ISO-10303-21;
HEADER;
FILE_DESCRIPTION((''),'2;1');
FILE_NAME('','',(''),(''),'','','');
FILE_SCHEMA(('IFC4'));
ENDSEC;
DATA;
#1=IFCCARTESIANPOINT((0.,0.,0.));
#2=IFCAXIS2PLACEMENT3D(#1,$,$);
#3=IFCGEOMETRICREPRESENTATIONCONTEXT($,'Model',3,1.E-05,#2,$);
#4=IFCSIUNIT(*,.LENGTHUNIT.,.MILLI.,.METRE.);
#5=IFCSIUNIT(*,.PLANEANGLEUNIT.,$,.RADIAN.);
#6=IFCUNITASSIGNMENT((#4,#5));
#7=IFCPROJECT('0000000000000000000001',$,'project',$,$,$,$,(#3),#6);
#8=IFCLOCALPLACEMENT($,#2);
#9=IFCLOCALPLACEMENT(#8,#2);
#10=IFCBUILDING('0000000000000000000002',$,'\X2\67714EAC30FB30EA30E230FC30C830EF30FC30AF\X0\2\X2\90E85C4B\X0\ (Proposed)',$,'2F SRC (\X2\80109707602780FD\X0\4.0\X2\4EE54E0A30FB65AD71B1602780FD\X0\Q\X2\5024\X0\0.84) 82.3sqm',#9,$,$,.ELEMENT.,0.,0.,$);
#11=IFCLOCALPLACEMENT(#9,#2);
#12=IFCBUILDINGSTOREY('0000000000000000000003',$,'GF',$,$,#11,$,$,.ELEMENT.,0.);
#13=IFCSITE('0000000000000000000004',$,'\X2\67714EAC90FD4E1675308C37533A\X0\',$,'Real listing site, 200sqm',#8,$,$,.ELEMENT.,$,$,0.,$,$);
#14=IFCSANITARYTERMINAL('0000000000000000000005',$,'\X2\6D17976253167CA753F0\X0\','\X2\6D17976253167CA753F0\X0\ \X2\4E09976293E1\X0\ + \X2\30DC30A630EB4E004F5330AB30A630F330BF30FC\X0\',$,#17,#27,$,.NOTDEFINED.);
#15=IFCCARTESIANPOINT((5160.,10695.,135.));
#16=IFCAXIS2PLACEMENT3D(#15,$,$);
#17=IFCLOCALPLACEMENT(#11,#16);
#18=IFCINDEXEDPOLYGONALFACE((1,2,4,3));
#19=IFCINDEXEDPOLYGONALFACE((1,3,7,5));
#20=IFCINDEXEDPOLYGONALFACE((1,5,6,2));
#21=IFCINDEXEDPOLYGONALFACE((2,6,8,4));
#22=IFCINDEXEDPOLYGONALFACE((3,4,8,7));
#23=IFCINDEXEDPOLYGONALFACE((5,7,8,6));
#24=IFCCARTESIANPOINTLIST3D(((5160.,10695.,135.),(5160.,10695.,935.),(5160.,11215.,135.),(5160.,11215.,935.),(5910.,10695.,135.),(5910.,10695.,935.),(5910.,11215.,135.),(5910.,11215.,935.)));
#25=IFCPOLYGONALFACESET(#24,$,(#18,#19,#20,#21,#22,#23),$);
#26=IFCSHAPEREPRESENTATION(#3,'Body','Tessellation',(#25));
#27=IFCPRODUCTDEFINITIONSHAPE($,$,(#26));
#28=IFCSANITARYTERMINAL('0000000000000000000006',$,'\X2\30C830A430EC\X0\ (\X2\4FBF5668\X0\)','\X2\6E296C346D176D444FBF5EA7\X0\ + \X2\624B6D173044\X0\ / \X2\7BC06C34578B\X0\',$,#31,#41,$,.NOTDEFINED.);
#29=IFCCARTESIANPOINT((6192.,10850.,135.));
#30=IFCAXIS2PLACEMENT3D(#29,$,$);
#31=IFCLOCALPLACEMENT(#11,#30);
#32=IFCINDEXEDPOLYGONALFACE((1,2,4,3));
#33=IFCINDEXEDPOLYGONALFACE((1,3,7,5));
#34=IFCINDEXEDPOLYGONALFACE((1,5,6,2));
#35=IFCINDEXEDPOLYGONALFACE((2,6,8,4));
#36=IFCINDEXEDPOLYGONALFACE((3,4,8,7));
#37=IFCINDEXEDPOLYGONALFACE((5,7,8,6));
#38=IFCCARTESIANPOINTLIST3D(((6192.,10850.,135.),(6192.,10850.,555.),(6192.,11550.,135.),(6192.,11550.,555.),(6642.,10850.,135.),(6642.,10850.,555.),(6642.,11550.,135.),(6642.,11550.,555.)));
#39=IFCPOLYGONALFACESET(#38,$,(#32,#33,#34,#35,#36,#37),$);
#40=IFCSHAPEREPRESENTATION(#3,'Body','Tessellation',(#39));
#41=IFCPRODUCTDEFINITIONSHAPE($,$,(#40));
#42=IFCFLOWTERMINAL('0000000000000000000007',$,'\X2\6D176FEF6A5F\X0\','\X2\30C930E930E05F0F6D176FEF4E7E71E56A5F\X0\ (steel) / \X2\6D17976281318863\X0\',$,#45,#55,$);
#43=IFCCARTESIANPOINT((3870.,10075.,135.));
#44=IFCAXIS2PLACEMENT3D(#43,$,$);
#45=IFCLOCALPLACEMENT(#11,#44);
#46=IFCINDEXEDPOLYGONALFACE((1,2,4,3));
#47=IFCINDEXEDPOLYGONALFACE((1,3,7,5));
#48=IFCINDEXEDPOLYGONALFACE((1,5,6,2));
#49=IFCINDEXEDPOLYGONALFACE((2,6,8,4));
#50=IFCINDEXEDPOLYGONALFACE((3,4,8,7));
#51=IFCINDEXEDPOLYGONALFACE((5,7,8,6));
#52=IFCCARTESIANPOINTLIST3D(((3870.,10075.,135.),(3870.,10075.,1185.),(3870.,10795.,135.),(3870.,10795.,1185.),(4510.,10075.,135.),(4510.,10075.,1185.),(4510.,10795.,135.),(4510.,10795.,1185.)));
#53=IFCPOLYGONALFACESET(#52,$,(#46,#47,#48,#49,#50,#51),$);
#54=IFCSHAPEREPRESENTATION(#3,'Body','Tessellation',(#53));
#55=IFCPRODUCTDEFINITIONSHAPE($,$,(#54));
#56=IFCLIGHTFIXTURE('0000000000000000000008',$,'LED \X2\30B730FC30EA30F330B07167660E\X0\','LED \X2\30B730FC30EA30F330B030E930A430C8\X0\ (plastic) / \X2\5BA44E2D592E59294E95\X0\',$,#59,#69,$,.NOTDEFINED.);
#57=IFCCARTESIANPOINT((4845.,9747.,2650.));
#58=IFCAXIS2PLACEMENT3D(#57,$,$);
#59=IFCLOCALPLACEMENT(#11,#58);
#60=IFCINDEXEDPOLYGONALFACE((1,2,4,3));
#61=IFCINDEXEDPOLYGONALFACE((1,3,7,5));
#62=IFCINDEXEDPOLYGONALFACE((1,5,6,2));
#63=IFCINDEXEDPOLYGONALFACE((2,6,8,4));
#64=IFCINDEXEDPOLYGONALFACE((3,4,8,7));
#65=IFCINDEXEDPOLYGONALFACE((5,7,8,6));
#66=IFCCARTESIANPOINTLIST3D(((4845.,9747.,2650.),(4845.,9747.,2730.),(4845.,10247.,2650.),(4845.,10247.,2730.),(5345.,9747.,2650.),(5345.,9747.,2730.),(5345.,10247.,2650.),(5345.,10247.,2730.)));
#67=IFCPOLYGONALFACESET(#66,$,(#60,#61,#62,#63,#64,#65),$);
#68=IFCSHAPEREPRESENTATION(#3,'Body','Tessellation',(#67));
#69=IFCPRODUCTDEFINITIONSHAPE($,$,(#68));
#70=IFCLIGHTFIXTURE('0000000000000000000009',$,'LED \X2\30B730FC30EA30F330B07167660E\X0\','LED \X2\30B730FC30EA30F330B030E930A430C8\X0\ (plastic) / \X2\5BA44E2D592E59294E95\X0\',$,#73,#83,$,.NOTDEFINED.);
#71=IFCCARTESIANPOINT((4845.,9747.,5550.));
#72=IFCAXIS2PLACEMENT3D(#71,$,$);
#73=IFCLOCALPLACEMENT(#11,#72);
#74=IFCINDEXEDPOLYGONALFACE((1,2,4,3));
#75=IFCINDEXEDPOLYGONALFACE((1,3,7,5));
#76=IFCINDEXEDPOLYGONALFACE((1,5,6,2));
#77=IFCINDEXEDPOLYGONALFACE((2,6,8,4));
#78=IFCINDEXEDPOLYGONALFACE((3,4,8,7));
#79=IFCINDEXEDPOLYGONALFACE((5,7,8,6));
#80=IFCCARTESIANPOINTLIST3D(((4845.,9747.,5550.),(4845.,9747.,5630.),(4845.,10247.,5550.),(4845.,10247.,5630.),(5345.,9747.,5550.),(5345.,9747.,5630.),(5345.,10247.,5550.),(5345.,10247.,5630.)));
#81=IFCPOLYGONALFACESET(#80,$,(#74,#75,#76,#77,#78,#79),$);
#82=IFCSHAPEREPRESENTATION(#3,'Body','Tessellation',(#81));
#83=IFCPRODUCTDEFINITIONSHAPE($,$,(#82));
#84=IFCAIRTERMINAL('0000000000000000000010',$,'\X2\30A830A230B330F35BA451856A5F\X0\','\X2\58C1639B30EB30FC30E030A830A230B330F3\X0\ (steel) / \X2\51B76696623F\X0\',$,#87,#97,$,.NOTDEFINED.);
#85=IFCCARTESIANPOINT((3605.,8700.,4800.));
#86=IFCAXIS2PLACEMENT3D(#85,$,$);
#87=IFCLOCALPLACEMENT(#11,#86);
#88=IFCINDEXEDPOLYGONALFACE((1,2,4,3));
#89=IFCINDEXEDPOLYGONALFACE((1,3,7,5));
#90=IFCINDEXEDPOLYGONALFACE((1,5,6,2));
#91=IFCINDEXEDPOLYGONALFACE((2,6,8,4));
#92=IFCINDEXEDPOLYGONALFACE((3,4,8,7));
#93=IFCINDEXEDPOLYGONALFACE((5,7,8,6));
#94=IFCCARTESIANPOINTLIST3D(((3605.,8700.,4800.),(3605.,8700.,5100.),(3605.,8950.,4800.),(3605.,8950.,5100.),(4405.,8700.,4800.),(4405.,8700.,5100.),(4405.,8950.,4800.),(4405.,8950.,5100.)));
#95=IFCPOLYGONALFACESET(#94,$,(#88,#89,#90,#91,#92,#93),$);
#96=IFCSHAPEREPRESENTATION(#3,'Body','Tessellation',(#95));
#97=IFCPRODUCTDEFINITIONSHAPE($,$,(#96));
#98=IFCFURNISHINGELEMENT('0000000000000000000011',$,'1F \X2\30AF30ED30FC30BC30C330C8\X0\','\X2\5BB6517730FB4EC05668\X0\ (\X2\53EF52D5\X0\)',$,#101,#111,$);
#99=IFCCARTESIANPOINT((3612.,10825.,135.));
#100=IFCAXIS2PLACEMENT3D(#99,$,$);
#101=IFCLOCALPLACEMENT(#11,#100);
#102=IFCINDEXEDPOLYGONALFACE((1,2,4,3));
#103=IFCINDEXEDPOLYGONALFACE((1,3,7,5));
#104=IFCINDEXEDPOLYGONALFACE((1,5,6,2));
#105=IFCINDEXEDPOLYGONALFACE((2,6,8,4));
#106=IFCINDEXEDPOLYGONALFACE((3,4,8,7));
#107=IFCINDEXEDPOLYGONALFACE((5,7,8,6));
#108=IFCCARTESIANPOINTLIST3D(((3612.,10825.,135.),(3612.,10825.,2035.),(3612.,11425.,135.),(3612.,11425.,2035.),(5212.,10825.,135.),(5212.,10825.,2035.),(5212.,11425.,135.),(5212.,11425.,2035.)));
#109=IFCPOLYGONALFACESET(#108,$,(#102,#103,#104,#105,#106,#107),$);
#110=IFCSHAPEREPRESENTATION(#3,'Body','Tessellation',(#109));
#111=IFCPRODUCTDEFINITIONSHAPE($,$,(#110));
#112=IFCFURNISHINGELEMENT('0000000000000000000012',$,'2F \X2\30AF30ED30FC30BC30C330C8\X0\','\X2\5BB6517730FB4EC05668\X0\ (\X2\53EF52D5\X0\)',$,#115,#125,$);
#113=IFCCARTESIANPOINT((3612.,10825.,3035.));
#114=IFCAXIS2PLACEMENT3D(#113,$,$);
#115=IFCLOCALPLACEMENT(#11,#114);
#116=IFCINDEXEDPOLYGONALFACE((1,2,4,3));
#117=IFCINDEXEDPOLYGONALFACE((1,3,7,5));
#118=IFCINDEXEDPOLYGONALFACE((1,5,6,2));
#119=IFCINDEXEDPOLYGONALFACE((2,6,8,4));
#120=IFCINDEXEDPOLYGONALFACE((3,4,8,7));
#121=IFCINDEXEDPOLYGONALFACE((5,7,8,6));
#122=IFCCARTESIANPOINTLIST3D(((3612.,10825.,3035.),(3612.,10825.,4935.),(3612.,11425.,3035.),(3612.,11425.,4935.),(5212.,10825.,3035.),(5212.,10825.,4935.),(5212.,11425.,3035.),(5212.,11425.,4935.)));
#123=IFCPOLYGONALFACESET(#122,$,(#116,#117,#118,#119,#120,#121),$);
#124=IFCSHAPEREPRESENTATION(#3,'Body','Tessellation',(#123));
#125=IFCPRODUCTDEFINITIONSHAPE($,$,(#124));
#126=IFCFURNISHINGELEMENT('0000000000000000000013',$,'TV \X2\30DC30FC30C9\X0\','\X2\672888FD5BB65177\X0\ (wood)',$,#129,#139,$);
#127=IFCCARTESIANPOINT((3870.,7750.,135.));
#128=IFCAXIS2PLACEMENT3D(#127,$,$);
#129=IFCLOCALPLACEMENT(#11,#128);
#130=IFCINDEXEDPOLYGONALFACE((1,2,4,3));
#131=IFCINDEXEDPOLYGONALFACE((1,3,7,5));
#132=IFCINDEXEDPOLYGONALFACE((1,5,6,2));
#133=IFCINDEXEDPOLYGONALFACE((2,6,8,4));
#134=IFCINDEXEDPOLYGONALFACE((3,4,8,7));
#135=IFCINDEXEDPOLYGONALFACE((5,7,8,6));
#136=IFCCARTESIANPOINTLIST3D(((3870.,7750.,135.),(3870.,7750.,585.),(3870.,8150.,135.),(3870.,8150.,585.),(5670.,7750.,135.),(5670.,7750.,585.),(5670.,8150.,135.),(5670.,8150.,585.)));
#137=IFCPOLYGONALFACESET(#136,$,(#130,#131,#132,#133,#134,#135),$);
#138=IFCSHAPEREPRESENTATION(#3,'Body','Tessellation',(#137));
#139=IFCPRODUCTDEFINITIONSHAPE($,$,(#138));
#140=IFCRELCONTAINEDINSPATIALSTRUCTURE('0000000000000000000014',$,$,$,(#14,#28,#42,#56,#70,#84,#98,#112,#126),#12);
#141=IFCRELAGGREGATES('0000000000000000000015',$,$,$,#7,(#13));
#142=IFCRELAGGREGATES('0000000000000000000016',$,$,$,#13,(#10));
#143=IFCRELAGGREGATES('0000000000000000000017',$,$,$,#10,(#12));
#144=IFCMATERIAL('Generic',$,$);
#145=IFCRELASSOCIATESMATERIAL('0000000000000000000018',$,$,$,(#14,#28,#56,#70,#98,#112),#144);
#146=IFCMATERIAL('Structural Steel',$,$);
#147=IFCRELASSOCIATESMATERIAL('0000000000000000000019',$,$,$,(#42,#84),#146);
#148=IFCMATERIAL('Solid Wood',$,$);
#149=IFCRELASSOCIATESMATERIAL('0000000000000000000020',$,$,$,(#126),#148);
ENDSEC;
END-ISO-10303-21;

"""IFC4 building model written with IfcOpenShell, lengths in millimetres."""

from ifc_helpers import new_model, si_unit, frame, frame_2d, origin, place, context, project, spatial, rectangle, extrude, material, element, save


model = new_model("IFC4")

# Units and contexts
model_context = context("Model", 3, precision=1e-05, world=origin())
ifc_project = project(units=[si_unit("LENGTHUNIT", "METRE", prefix="MILLI"), si_unit("PLANEANGLEUNIT", "RADIAN")], contexts=[model_context])

# Site, building, storey
site_placement = place(None, origin())
site = spatial("IfcSite", under=ifc_project, at=site_placement, Name="東京都世田谷区", ObjectType="Real listing site, 200sqm", CompositionType="ELEMENT", RefElevation=0.0)
building_placement = place(site_placement, origin())
building = spatial("IfcBuilding", under=site, at=building_placement, Name="東京・リモートワーク2部屋 (Proposed)", ObjectType="2F SRC (耐震性能4.0以上・断熱性能Q値0.84) 82.3sqm", CompositionType="ELEMENT", ElevationOfRefHeight=0.0, ElevationOfTerrain=0.0)
storey_placement = place(building_placement, origin())
storey = spatial("IfcBuildingStorey", under=building, at=storey_placement, Name="GF", CompositionType="ELEMENT", Elevation=0.0)

# Shared definitions
ifc_material_1 = material(Name="Solid Wood")

# Sanitary terminals
ifc_material_2 = material(Name="Generic")
sanitary_terminal_1_placement = place(storey_placement, frame((5160.0, 10695.0, 135.0)))
element("IfcSanitaryTerminal", 1, at=sanitary_terminal_1_placement, inside=storey, material=ifc_material_2, Name="洗面化粧台", Description="洗面化粧台 三面鏡 + ボウル一体カウンター", PredefinedType="NOTDEFINED", context=model_context, shape_type="SweptSolid", body=[
    extrude(rectangle(XDim=750.0, YDim=520.0, at=frame_2d((375.0, 260.0))), frame((5160.0, 10695.0, 135.0)), (0.0, 0.0, 1.0), 800.0),
])
sanitary_terminal_2_placement = place(storey_placement, frame((6192.0, 10850.0, 135.0)))
element("IfcSanitaryTerminal", 2, at=sanitary_terminal_2_placement, inside=storey, material=ifc_material_2, Name="トイレ (便器)", Description="温水洗浄便座 + 手洗い / 節水型", PredefinedType="NOTDEFINED", context=model_context, shape_type="SweptSolid", body=[
    extrude(rectangle(XDim=450.0, YDim=700.0, at=frame_2d((225.0, 350.0))), frame((6192.0, 10850.0, 135.0)), (0.0, 0.0, 1.0), 420.0),
])

# Flow terminal
ifc_material_3 = material(Name="Structural Steel")
flow_terminal_placement = place(storey_placement, frame((3870.0, 10075.0, 135.0)))
element("IfcFlowTerminal", 3, at=flow_terminal_placement, inside=storey, material=ifc_material_3, Name="洗濯機", Description="ドラム式洗濯乾燥機 (steel) / 洗面脱衣", context=model_context, shape_type="SweptSolid", body=[
    extrude(rectangle(XDim=640.0, YDim=720.0, at=frame_2d((320.0, 360.0))), frame((3870.0, 10075.0, 135.0)), (0.0, 0.0, 1.0), 1050.0),
])

# Light fixtures
light_fixture_1_placement = place(storey_placement, frame((4845.0, 9747.0, 2650.0)))
element("IfcLightFixture", 4, at=light_fixture_1_placement, inside=storey, material=ifc_material_2, Name="LED シーリング照明", Description="LED シーリングライト (plastic) / 室中央天井", PredefinedType="NOTDEFINED", context=model_context, shape_type="SweptSolid", body=[
    extrude(rectangle(XDim=500.0, YDim=500.0, at=frame_2d((250.0, 250.0))), frame((4845.0, 9747.0, 2650.0)), (0.0, 0.0, 1.0), 80.0),
])
light_fixture_2_placement = place(storey_placement, frame((4845.0, 9747.0, 5550.0)))
element("IfcLightFixture", 5, at=light_fixture_2_placement, inside=storey, material=ifc_material_2, Name="LED シーリング照明", Description="LED シーリングライト (plastic) / 室中央天井", PredefinedType="NOTDEFINED", context=model_context, shape_type="SweptSolid", body=[
    extrude(rectangle(XDim=500.0, YDim=500.0, at=frame_2d((250.0, 250.0))), frame((4845.0, 9747.0, 5550.0)), (0.0, 0.0, 1.0), 80.0),
])

# Air terminal
air_terminal_placement = place(storey_placement, frame((3605.0, 8700.0, 4800.0)))
element("IfcAirTerminal", 6, at=air_terminal_placement, inside=storey, material=ifc_material_3, Name="エアコン室内機", Description="壁掛ルームエアコン (steel) / 冷暖房", PredefinedType="NOTDEFINED", context=model_context, shape_type="SweptSolid", body=[
    extrude(rectangle(XDim=800.0, YDim=250.0, at=frame_2d((400.0, 125.0))), frame((3605.0, 8700.0, 4800.0)), (0.0, 0.0, 1.0), 300.0),
])

# Furnishing elements
furnishing_1_placement = place(storey_placement, frame((3612.0, 10825.0, 135.0)))
element("IfcFurnishingElement", 7, at=furnishing_1_placement, inside=storey, material=ifc_material_2, Name="1F クローゼット", Description="家具・什器 (可動)", context=model_context, shape_type="SweptSolid", body=[
    extrude(rectangle(XDim=1600.0, YDim=600.0, at=frame_2d((800.0, 300.0))), frame((3612.0, 10825.0, 135.0)), (0.0, 0.0, 1.0), 1900.0),
])
furnishing_2_placement = place(storey_placement, frame((3612.0, 10825.0, 3035.0)))
element("IfcFurnishingElement", 8, at=furnishing_2_placement, inside=storey, material=ifc_material_2, Name="2F クローゼット", Description="家具・什器 (可動)", context=model_context, shape_type="SweptSolid", body=[
    extrude(rectangle(XDim=1600.0, YDim=600.0, at=frame_2d((800.0, 300.0))), frame((3612.0, 10825.0, 3035.0)), (0.0, 0.0, 1.0), 1900.0),
])
furnishing_3_placement = place(storey_placement, frame((3870.0, 7750.0, 135.0)))
element("IfcFurnishingElement", 9, at=furnishing_3_placement, inside=storey, material=ifc_material_1, Name="TV ボード", Description="木製家具 (wood)", context=model_context, shape_type="SweptSolid", body=[
    extrude(rectangle(XDim=1800.0, YDim=400.0, at=frame_2d((900.0, 200.0))), frame((3870.0, 7750.0, 135.0)), (0.0, 0.0, 1.0), 450.0),
])

save(model, "model.ifc")
